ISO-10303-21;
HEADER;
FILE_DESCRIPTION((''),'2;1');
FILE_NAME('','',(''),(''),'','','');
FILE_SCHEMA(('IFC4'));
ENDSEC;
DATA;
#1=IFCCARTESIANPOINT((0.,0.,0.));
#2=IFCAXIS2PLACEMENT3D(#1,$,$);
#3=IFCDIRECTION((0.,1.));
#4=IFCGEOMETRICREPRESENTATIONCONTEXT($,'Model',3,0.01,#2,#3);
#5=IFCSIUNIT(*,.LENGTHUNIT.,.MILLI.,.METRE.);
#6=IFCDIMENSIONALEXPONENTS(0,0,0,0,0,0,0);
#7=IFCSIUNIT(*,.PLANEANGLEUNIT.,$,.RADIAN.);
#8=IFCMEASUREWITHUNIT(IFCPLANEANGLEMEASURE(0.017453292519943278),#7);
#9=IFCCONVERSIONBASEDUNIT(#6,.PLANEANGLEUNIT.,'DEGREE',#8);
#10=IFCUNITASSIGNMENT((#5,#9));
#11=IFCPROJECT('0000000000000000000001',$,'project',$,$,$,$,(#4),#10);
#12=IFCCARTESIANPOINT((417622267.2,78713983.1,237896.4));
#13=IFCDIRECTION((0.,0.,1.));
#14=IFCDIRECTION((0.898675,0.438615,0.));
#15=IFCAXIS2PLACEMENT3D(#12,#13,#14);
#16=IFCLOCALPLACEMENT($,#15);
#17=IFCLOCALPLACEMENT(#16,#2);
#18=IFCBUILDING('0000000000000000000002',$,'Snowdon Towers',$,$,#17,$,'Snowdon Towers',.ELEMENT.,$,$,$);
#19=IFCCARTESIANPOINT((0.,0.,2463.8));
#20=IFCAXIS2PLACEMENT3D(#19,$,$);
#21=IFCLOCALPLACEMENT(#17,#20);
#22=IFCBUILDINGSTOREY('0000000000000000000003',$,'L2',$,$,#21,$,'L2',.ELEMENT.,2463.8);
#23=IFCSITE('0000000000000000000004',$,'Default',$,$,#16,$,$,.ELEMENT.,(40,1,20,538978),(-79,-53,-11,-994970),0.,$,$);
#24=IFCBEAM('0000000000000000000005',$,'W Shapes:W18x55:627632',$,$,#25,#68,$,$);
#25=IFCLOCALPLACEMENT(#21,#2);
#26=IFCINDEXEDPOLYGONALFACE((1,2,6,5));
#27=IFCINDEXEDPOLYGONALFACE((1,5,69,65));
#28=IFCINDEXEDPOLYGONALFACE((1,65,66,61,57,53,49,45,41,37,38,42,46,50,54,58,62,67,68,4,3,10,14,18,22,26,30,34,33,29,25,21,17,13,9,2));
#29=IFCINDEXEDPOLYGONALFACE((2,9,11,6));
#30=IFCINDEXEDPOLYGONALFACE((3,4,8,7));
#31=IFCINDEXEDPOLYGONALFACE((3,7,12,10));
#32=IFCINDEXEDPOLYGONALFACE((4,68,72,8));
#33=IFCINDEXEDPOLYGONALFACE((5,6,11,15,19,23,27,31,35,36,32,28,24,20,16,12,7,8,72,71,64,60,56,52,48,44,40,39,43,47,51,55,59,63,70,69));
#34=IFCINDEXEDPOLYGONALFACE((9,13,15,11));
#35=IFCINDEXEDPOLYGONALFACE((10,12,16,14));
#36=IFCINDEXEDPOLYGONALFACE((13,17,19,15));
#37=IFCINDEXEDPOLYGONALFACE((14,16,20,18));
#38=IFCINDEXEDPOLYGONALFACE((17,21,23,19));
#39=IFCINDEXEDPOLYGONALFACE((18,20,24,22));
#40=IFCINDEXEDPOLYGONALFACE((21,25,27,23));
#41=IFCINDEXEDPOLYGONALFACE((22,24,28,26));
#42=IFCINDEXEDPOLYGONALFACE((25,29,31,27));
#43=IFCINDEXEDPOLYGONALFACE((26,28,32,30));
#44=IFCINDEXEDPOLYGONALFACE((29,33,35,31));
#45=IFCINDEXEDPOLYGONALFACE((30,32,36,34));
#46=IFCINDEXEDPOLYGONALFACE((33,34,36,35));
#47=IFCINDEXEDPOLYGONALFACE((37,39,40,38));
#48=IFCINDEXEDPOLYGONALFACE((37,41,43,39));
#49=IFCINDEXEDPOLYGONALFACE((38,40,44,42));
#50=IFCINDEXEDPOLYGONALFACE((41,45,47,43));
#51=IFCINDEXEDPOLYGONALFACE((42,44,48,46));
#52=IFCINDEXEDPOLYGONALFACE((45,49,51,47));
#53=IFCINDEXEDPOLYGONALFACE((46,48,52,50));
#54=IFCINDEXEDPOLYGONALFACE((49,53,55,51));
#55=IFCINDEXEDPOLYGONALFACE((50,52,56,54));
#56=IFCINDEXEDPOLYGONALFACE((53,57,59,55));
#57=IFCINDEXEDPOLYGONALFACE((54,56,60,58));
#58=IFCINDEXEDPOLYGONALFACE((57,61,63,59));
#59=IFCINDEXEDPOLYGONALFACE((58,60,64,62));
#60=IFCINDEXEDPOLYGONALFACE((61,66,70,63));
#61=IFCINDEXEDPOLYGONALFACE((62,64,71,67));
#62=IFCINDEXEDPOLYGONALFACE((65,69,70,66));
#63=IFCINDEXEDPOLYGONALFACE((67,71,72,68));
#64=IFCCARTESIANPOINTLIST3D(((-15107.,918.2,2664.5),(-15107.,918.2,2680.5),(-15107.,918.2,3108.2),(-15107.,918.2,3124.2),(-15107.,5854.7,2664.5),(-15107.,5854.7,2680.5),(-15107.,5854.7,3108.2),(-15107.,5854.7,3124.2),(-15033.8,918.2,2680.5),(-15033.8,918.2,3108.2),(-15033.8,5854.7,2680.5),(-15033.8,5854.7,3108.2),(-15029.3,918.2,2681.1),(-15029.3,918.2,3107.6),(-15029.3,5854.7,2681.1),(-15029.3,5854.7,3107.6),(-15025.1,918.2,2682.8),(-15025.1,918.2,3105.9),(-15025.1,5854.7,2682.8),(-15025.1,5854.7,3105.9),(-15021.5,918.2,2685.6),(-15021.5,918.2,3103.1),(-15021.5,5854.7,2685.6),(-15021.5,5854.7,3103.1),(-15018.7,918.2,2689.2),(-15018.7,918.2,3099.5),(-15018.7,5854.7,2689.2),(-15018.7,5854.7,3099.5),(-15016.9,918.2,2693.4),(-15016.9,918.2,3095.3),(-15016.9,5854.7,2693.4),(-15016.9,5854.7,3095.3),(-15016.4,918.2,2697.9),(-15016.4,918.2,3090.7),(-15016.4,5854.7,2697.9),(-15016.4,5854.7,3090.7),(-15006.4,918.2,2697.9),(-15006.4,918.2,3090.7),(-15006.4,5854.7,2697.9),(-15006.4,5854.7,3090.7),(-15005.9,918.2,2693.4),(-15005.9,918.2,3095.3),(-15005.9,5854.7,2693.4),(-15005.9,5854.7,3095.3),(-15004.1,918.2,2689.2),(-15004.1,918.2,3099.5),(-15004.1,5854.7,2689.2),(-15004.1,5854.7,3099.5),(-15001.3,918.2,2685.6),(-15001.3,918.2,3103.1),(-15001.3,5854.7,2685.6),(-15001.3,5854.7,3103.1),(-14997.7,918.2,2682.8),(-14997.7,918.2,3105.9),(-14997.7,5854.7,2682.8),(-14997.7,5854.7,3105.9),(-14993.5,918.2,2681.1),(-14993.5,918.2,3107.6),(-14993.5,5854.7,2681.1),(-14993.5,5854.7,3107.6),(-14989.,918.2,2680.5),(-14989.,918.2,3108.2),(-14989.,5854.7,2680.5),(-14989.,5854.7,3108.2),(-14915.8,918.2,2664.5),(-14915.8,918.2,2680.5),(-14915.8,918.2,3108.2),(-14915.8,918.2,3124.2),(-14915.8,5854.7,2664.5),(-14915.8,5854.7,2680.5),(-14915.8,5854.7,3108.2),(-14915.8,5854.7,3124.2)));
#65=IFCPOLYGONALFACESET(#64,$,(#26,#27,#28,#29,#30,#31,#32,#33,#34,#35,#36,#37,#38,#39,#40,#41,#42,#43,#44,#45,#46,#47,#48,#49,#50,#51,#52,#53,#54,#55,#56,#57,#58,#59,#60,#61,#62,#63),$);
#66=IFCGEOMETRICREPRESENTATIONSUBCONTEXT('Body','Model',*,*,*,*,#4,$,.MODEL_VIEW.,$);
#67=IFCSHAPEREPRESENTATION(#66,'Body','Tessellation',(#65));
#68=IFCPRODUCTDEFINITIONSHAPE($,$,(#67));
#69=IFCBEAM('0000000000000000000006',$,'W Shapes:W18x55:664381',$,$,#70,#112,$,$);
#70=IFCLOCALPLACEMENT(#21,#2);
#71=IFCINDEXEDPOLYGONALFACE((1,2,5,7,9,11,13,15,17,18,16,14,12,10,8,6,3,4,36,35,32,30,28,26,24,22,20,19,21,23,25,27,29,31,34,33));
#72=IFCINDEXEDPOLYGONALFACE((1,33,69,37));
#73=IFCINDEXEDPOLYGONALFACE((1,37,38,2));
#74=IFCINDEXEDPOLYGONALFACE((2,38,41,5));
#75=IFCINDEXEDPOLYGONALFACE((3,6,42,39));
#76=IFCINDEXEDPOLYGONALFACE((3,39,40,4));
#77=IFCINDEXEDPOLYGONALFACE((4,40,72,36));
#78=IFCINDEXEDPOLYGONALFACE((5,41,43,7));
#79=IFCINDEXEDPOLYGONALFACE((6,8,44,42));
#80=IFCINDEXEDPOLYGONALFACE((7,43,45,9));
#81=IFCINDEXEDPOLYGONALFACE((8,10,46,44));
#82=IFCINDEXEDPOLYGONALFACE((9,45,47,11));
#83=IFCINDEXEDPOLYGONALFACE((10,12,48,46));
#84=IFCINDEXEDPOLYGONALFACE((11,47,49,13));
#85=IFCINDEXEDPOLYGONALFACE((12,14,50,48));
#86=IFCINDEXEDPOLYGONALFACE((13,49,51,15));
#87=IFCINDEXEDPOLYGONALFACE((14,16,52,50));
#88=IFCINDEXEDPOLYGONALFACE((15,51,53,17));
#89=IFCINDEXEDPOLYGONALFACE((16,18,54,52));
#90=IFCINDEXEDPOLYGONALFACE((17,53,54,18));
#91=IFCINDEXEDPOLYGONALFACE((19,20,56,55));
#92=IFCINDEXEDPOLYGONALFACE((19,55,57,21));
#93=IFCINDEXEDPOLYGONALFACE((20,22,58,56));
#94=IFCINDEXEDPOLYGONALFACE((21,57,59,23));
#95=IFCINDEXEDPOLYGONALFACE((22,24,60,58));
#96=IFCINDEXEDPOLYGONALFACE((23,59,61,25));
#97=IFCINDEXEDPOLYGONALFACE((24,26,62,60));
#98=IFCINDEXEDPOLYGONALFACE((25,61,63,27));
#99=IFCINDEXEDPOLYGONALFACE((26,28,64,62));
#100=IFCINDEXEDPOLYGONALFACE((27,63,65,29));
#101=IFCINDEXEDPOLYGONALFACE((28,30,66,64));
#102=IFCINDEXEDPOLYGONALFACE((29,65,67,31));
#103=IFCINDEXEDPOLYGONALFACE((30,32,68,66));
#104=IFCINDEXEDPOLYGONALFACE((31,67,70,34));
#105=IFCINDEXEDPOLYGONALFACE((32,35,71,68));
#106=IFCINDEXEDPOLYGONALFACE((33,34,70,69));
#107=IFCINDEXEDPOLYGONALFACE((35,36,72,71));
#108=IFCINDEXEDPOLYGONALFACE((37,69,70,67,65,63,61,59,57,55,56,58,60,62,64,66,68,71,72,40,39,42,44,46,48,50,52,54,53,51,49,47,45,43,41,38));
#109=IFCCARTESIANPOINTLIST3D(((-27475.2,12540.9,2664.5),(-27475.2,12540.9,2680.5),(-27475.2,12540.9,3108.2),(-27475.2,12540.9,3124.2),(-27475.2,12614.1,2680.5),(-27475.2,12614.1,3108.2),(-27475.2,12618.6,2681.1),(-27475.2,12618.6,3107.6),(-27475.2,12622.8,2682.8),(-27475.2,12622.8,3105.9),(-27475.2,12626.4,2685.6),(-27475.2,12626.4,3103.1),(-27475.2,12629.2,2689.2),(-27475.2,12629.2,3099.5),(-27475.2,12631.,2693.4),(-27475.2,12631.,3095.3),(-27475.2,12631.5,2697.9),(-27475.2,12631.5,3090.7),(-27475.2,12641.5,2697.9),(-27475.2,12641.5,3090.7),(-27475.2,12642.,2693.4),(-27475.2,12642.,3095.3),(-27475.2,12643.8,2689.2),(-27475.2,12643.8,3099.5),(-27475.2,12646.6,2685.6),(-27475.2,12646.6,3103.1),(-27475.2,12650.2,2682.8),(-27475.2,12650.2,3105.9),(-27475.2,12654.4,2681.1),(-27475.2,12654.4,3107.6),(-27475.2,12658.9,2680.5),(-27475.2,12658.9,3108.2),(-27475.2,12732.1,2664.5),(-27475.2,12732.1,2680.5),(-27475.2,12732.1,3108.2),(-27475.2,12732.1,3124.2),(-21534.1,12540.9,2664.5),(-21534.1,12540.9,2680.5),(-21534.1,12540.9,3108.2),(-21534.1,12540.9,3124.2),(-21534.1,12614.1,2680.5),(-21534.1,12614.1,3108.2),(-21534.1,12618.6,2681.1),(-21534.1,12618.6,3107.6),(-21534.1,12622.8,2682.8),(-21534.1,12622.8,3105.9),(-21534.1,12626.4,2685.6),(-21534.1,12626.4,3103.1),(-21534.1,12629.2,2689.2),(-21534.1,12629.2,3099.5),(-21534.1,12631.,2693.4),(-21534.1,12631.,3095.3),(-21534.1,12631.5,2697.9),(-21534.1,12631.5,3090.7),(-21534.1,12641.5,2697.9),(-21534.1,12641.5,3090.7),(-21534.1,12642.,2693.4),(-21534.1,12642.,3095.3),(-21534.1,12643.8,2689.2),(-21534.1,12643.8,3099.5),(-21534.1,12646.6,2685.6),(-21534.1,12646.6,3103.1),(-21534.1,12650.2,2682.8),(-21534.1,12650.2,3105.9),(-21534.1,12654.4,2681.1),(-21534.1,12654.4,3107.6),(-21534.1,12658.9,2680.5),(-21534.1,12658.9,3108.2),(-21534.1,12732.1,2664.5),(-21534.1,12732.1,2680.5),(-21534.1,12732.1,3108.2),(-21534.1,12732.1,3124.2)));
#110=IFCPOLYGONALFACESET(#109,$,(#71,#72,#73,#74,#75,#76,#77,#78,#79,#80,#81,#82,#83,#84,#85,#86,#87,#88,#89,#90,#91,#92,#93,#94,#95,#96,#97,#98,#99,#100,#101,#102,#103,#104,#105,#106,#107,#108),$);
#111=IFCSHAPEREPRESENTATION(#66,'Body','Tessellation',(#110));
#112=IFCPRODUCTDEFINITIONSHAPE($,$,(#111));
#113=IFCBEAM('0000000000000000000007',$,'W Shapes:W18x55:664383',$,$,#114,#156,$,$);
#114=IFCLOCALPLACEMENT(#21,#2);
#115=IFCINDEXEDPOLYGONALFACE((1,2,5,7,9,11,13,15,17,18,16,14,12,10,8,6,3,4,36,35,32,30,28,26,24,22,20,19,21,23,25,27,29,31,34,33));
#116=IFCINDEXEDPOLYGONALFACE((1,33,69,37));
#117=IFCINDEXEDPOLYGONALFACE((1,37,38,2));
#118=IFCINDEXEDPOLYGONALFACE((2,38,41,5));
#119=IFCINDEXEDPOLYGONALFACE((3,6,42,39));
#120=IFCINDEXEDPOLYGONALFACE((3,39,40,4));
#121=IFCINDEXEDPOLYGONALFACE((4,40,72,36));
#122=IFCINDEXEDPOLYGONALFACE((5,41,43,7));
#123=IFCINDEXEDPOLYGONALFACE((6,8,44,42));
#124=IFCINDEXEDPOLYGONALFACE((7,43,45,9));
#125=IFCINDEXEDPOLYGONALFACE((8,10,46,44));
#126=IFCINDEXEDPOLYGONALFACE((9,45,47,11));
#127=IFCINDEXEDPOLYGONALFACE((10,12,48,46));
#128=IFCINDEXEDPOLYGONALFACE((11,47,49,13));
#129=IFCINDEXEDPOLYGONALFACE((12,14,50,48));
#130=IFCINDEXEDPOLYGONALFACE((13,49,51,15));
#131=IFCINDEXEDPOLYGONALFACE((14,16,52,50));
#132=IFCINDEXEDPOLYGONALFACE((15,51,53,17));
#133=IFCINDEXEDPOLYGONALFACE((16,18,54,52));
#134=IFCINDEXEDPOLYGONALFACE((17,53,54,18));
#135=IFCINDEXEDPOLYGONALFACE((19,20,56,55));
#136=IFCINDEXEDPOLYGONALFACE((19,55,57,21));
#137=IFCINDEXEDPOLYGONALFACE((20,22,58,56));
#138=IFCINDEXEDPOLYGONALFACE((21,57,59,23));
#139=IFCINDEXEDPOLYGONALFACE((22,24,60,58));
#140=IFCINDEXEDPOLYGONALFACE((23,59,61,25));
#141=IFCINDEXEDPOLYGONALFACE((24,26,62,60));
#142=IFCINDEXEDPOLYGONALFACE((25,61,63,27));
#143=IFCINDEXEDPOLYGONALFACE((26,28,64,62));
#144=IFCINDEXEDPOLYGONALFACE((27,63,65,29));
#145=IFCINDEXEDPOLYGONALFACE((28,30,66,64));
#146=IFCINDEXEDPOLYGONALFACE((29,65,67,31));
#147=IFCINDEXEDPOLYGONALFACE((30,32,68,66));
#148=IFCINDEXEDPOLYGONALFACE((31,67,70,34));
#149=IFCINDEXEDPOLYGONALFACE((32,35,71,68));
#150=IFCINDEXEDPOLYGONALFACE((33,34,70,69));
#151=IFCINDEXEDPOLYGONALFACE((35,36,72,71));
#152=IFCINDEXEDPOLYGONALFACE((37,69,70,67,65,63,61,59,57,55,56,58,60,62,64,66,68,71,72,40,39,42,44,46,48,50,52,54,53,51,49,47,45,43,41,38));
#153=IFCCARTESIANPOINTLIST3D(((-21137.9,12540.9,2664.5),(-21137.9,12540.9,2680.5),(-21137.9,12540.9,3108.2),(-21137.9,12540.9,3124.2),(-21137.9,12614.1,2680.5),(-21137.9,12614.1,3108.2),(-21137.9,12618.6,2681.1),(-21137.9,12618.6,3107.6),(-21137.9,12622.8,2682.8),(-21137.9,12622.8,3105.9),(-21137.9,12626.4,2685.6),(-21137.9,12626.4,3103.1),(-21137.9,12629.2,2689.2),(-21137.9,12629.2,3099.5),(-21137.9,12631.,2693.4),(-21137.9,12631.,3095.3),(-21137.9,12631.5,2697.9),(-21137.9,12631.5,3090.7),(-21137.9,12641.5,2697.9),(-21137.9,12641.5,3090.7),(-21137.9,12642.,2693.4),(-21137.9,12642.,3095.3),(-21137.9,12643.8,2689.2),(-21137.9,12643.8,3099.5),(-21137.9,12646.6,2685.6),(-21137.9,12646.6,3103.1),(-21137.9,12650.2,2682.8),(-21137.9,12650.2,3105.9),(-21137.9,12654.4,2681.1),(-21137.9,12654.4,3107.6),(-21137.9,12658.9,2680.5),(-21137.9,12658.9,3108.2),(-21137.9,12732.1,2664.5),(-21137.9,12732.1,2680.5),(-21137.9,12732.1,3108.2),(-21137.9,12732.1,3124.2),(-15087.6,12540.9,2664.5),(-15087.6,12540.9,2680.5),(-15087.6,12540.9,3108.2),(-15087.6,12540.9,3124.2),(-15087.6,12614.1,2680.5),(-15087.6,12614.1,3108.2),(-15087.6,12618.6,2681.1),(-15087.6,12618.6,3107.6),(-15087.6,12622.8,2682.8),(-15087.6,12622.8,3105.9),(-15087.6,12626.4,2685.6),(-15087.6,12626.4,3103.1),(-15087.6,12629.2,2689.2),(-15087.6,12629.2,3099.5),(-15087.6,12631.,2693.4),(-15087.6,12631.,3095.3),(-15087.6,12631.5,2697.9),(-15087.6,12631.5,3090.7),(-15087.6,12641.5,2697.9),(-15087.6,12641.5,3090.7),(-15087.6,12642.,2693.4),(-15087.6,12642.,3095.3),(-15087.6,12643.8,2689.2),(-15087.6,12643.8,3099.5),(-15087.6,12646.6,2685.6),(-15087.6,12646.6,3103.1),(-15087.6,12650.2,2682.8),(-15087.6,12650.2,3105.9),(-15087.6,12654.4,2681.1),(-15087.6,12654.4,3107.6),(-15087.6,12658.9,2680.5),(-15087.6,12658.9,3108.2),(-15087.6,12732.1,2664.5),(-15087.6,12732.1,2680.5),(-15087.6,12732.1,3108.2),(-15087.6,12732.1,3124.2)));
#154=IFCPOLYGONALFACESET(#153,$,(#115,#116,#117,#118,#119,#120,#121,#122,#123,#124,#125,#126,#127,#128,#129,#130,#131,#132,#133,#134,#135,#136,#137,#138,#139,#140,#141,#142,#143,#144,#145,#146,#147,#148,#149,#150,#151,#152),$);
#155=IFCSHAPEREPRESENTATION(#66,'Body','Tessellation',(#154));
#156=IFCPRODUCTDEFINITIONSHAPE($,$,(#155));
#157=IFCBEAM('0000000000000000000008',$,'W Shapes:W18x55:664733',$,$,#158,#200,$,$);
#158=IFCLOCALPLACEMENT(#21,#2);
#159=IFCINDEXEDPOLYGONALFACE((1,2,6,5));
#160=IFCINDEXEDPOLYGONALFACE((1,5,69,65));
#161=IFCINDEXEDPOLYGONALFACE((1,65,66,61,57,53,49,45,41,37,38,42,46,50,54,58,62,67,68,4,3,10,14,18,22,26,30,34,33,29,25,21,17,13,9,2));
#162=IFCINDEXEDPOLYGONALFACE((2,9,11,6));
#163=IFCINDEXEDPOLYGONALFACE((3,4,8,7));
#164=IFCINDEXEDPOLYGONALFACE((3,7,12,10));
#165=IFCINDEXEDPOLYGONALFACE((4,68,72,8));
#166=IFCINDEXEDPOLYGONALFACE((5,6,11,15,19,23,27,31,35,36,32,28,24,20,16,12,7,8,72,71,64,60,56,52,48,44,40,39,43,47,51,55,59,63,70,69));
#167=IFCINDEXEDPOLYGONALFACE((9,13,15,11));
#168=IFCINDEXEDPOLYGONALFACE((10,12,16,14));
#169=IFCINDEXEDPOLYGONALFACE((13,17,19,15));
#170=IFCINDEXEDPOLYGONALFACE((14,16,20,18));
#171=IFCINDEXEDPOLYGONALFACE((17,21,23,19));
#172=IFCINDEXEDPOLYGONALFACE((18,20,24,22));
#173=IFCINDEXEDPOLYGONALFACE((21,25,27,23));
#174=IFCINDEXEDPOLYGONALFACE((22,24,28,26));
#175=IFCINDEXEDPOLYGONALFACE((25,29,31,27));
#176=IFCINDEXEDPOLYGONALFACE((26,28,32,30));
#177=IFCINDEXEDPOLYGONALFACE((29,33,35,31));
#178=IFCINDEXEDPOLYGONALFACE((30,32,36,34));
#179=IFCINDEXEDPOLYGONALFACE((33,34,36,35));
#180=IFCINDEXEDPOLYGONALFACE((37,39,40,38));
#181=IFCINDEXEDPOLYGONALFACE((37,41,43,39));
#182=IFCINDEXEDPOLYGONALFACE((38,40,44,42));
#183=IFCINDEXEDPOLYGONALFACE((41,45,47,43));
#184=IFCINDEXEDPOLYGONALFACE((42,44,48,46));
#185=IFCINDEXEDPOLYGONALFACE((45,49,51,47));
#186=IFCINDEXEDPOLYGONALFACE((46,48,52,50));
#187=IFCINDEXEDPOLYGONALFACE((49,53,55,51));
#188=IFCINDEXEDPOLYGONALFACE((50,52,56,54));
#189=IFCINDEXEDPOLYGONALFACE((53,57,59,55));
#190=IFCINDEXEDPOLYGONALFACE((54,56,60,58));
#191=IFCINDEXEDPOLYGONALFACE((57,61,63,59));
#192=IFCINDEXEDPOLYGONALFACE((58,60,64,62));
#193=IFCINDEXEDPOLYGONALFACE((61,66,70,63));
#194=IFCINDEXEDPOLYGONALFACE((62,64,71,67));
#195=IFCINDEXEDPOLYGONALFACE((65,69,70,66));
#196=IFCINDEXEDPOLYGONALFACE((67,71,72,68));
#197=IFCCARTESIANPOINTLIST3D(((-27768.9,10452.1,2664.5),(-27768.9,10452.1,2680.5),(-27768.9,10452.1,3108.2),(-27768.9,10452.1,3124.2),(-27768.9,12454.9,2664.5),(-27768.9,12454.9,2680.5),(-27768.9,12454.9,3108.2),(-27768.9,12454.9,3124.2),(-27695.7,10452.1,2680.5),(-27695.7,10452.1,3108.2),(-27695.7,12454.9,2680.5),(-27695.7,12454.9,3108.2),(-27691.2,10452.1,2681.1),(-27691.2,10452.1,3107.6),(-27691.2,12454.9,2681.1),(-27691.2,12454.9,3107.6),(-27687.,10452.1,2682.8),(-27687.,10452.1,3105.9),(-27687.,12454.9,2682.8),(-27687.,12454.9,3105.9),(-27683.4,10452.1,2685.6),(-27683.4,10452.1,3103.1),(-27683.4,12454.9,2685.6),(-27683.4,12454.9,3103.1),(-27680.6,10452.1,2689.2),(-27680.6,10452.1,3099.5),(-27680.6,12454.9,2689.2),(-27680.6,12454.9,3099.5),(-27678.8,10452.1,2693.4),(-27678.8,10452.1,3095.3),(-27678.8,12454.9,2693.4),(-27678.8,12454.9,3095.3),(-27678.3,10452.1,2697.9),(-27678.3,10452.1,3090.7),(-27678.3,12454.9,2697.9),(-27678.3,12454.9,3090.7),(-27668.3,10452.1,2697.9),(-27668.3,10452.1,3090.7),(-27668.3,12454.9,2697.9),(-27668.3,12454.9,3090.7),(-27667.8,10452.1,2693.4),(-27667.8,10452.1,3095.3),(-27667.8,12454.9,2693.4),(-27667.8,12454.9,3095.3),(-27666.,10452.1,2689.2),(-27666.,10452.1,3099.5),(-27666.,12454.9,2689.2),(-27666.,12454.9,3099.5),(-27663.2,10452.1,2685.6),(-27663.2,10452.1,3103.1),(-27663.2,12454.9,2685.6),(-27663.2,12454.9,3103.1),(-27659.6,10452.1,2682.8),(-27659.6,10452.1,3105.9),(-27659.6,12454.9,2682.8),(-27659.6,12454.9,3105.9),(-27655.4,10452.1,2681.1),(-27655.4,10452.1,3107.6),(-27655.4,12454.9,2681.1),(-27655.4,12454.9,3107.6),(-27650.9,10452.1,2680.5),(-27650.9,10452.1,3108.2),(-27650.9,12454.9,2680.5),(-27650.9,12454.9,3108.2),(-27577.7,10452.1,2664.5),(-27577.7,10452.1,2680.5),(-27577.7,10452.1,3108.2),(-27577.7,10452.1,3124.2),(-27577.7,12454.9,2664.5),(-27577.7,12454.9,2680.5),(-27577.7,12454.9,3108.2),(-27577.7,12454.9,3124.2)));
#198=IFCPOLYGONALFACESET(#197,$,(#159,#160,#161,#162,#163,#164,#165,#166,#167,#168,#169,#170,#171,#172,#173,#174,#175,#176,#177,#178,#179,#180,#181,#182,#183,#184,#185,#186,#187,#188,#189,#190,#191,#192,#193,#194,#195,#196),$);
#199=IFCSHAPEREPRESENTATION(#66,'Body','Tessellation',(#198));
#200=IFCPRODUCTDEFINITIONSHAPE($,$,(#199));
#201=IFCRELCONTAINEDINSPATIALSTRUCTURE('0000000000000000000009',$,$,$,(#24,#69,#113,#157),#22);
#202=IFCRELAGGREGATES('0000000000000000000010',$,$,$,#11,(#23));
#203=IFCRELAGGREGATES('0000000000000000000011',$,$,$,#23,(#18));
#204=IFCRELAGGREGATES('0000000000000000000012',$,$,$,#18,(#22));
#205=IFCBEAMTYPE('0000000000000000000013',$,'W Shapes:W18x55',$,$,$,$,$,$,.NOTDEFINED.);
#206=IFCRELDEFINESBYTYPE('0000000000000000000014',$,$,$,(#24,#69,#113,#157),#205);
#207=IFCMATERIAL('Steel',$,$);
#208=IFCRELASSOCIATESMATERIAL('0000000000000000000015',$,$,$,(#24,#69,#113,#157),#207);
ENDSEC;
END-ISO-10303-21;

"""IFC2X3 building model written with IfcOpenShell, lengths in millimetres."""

from ifc_helpers import new_model, entity, si_unit, converted_unit, direction, frame, frame_2d, origin, place, context, subcontext, project, spatial, i_section, extrude, material, type_object, element, save


model = new_model("IFC2X3")

# Units and contexts
model_context = context("Model", 3, precision=0.01, world=origin(), true_north=direction((0.0, 1.0)))
body_context = subcontext(model_context, "Body", "Model", "MODEL_VIEW")
ifc_project = project(units=[si_unit("LENGTHUNIT", "METRE", prefix="MILLI"), converted_unit("PLANEANGLEUNIT", "DEGREE", entity("IfcPlaneAngleMeasure", 0.017453292519943278), si_unit("PLANEANGLEUNIT", "RADIAN"), dimensions=[0, 0, 0, 0, 0, 0, 0])], contexts=[model_context])

# Site, building, storey
site_placement = place(None, frame((417622267.2, 78713983.1, 237896.4), z_axis=(0.0, 0.0, 1.0), x_axis=(0.898675, 0.438615, 0.0)))
site = spatial("IfcSite", under=ifc_project, at=site_placement, Name="Default", CompositionType="ELEMENT", RefLatitude=(40, 1, 20, 538978), RefLongitude=(-79, -53, -11, -994970), RefElevation=0.0)
building_placement = place(site_placement, origin())
building = spatial("IfcBuilding", under=site, at=building_placement, Name="Snowdon Towers", LongName="Snowdon Towers", CompositionType="ELEMENT")
storey_placement = place(building_placement, frame((0.0, 0.0, 2463.8)))
storey = spatial("IfcBuildingStorey", under=building, at=storey_placement, Name="L2", LongName="L2", CompositionType="ELEMENT", Elevation=2463.8)

# Beams
ifc_material_1 = material(Name="Steel")
beam_type_1 = type_object("IfcBeamType", Name="W Shapes:W18x55", PredefinedType="NOTDEFINED")
beam_1_placement = place(storey_placement, frame((-15011.4, 5854.7, 3124.2), z_axis=(0.0, 0.0, 1.0), x_axis=(0.0, -1.0, 0.0)))
element("IfcBeam", 1, at=beam_1_placement, inside=storey, type_object=beam_type_1, material=ifc_material_1, Name="W Shapes:W18x55:627632", context=body_context, shape_type="SweptSolid", body=[
    extrude(i_section(OverallWidth=191.3, OverallDepth=459.7, WebThickness=9.9, FlangeThickness=16.0, FilletRadius=17.5, at=frame_2d((0.0, 0.0), x_axis=(0.0, 1.0))), frame((0.0, 0.0, -229.9), z_axis=(1.0, 0.0, 0.0), x_axis=(0.0, 0.0, -1.0)), (0.0, 0.0, 1.0), 4936.5),
])
beam_2_placement = place(storey_placement, frame((-27647.9, 12636.5, 3124.2)))
element("IfcBeam", 2, at=beam_2_placement, inside=storey, type_object=beam_type_1, material=ifc_material_1, Name="W Shapes:W18x55:664381", context=body_context, shape_type="SweptSolid", body=[
    extrude(i_section(OverallWidth=191.3, OverallDepth=459.7, WebThickness=9.9, FlangeThickness=16.0, FilletRadius=17.5, at=frame_2d((0.0, 0.0), x_axis=(0.0, 1.0))), frame((172.7, 0.0, -229.9), z_axis=(1.0, 0.0, 0.0), x_axis=(0.0, 0.0, -1.0)), (0.0, 0.0, 1.0), 5941.1),
])
beam_3_placement = place(storey_placement, frame((-21336.0, 12636.5, 3124.2)))
element("IfcBeam", 3, at=beam_3_placement, inside=storey, type_object=beam_type_1, material=ifc_material_1, Name="W Shapes:W18x55:664383", context=body_context, shape_type="SweptSolid", body=[
    extrude(i_section(OverallWidth=191.3, OverallDepth=459.7, WebThickness=9.9, FlangeThickness=16.0, FilletRadius=17.5, at=frame_2d((0.0, 0.0), x_axis=(0.0, 1.0))), frame((198.1, 0.0, -229.9), z_axis=(1.0, 0.0, 0.0), x_axis=(0.0, 0.0, -1.0)), (0.0, 0.0, 1.0), 6050.3),
])
beam_4_placement = place(storey_placement, frame((-27673.3, 12636.5, 3124.2), z_axis=(0.0, 0.0, 1.0), x_axis=(0.0, -1.0, 0.0)))
element("IfcBeam", 4, at=beam_4_placement, inside=storey, type_object=beam_type_1, material=ifc_material_1, Name="W Shapes:W18x55:664733", context=body_context, shape_type="SweptSolid", body=[
    extrude(i_section(OverallWidth=191.3, OverallDepth=459.7, WebThickness=9.9, FlangeThickness=16.0, FilletRadius=17.5, at=frame_2d((0.0, 0.0), x_axis=(0.0, 1.0))), frame((181.6, 0.0, -229.9), z_axis=(1.0, 0.0, 0.0), x_axis=(0.0, 0.0, -1.0)), (0.0, 0.0, 1.0), 2002.8),
])

save(model, "model.ifc")
